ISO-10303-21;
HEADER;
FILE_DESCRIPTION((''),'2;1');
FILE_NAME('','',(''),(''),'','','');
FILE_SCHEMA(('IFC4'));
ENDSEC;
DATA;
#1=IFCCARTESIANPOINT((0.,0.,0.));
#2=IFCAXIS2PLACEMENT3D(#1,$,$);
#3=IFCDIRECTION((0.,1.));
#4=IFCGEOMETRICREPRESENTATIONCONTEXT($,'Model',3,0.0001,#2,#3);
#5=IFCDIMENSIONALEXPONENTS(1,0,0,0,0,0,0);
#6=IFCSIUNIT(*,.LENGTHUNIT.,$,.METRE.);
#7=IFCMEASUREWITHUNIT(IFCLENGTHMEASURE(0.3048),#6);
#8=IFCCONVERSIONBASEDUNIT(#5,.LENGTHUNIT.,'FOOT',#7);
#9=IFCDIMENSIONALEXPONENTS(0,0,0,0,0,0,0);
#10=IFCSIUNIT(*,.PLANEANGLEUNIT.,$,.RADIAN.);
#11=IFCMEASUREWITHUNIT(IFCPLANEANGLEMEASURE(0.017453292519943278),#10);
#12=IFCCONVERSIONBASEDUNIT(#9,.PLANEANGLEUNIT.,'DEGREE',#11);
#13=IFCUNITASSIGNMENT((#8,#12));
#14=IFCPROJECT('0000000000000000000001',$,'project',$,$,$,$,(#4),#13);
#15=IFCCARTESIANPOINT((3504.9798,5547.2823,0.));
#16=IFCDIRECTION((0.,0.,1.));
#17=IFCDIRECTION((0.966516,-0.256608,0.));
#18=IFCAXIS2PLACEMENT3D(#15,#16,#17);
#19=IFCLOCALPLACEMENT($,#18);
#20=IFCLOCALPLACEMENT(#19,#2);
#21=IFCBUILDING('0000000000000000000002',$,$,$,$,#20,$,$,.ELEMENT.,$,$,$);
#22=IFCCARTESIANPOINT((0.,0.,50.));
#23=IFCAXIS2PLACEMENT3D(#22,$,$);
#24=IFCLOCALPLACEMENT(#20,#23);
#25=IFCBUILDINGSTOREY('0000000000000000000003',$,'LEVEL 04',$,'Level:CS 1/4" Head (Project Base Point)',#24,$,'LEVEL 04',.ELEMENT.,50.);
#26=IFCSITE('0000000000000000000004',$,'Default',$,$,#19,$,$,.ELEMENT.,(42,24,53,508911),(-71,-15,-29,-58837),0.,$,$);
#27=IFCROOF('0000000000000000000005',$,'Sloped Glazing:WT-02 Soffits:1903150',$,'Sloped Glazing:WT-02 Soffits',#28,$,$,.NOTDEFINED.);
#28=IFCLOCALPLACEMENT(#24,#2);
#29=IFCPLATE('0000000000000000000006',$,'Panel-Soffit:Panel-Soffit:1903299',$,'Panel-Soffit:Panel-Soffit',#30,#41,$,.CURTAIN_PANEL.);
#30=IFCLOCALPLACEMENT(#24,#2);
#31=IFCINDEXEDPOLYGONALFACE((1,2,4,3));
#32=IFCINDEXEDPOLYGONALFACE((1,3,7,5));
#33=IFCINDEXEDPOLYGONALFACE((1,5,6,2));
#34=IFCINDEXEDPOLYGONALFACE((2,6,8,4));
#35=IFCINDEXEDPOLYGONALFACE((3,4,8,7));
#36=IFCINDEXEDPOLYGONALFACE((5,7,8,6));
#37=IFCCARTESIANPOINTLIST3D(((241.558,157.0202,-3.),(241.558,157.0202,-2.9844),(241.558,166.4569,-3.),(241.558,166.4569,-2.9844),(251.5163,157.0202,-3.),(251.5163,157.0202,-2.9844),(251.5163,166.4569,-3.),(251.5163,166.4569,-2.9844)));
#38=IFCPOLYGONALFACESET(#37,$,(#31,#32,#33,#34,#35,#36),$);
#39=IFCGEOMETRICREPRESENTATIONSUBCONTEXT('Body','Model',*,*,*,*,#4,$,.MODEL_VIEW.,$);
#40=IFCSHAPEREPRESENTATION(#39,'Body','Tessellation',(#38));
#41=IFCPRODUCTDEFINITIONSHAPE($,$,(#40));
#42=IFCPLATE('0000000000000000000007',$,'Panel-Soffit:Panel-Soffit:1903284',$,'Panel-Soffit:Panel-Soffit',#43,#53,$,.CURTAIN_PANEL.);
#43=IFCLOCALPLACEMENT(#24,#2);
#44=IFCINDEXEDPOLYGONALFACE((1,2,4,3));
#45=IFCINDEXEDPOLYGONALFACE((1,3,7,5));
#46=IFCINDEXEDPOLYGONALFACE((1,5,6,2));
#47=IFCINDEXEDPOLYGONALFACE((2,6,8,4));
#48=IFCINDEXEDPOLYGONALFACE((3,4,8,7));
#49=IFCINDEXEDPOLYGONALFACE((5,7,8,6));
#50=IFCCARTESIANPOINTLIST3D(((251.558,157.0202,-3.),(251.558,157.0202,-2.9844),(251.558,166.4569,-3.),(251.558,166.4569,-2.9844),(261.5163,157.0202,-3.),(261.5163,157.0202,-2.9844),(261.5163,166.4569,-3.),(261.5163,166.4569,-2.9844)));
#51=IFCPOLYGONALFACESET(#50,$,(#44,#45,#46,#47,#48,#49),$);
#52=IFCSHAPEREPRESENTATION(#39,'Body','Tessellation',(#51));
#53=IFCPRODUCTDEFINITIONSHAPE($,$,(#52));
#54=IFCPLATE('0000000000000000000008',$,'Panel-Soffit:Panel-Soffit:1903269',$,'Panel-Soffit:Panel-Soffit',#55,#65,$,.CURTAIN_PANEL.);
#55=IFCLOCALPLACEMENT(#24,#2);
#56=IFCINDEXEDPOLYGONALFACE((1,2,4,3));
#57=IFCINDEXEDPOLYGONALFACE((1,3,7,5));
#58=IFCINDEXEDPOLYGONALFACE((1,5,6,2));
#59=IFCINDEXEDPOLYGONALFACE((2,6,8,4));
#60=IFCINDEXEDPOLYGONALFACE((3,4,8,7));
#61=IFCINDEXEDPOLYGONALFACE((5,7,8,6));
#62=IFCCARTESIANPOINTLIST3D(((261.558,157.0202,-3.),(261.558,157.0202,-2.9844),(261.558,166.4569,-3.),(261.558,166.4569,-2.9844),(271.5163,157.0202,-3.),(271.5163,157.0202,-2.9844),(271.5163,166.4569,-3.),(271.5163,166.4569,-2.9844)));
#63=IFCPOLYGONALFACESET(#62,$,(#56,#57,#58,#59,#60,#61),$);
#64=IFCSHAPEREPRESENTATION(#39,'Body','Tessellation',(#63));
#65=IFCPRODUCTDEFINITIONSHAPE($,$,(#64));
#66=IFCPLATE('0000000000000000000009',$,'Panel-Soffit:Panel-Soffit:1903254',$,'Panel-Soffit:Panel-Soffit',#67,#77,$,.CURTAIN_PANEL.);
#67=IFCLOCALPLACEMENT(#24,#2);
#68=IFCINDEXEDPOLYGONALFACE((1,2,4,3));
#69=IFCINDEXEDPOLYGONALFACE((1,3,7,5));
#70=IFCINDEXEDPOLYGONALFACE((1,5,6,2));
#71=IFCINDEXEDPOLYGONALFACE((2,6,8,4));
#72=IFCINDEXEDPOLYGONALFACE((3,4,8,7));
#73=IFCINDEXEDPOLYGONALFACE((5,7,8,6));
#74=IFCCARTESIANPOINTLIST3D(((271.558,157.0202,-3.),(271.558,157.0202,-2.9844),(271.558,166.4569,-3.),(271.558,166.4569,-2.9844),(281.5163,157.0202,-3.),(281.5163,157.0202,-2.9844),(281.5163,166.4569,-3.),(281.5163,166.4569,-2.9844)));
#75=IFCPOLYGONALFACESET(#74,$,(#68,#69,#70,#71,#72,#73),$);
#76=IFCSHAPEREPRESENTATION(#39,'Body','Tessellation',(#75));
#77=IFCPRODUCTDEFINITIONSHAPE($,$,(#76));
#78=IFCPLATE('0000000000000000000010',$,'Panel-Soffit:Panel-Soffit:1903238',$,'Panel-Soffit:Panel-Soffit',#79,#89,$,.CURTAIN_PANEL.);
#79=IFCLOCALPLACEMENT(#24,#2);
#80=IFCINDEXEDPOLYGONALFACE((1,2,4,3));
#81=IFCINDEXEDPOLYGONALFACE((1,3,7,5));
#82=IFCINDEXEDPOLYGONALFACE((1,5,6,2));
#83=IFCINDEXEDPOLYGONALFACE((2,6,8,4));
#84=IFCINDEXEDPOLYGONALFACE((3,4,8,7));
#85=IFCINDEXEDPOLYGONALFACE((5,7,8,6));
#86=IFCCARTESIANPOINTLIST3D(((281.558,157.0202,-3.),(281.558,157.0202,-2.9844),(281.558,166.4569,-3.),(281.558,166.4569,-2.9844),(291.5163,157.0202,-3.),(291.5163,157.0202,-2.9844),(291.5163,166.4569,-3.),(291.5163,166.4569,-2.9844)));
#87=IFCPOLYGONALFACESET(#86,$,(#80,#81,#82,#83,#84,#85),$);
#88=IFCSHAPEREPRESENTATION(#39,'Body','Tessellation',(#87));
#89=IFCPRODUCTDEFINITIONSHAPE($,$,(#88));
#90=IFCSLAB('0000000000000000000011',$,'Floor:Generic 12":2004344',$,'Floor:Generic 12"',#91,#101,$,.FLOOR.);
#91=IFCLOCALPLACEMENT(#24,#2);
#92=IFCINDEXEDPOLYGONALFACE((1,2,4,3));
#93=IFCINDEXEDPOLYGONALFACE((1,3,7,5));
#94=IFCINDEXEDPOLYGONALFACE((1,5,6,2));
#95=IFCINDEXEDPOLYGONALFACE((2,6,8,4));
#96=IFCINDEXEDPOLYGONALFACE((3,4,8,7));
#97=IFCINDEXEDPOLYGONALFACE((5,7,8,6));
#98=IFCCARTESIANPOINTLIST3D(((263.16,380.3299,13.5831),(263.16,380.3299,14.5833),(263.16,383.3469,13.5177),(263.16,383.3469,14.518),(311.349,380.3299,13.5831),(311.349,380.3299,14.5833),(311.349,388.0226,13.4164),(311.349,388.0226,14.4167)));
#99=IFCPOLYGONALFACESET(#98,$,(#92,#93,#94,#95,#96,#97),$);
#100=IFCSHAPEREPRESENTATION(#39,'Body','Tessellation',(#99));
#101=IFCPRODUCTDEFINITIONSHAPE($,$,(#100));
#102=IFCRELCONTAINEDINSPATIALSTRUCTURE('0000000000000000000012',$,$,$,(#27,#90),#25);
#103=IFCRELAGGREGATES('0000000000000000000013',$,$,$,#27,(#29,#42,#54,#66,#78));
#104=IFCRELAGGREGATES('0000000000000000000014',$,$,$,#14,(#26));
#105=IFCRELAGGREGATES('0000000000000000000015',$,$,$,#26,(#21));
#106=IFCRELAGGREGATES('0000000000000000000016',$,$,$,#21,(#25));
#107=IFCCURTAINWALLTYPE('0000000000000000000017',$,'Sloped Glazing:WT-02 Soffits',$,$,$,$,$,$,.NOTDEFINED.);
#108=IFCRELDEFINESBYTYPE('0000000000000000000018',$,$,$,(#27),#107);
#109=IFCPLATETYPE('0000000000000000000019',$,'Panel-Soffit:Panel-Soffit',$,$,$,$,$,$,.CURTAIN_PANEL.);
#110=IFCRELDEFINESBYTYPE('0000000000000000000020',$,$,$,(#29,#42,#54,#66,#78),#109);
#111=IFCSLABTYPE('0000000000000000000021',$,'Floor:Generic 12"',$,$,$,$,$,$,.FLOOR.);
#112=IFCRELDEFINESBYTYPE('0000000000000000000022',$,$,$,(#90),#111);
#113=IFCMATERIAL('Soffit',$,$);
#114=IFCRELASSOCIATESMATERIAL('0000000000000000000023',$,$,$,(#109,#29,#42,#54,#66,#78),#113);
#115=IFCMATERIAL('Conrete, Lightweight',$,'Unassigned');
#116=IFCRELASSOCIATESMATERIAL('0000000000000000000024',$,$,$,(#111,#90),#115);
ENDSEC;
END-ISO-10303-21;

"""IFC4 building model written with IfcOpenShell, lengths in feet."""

from ifc_helpers import new_model, entity, si_unit, converted_unit, direction, frame, origin, place, context, subcontext, project, spatial, polyline, indexed_curve, outline, extrude, source, transform, mapped, material, type_object, type_shapes, element, aggregate, save


model = new_model("IFC4")

# Units and contexts
model_context = context("Model", 3, precision=0.0001, world=origin(), true_north=direction((0.0, 1.0)))
body_context = subcontext(model_context, "Body", "Model", "MODEL_VIEW")
ifc_project = project(units=[converted_unit("LENGTHUNIT", "FOOT", entity("IfcLengthMeasure", 0.3048), si_unit("LENGTHUNIT", "METRE"), dimensions=[1, 0, 0, 0, 0, 0, 0]), converted_unit("PLANEANGLEUNIT", "DEGREE", entity("IfcPlaneAngleMeasure", 0.017453292519943278), si_unit("PLANEANGLEUNIT", "RADIAN"), dimensions=[0, 0, 0, 0, 0, 0, 0])], contexts=[model_context])

# Site, building, storey
site_placement = place(None, frame((3504.9798, 5547.2823, 0.0), z_axis=(0.0, 0.0, 1.0), x_axis=(0.966516, -0.256608, 0.0)))
site = spatial("IfcSite", under=ifc_project, at=site_placement, Name="Default", CompositionType="ELEMENT", RefLatitude=(42, 24, 53, 508911), RefLongitude=(-71, -15, -29, -58837), RefElevation=0.0)
building_placement = place(site_placement, origin())
building = spatial("IfcBuilding", under=site, at=building_placement, CompositionType="ELEMENT")
storey_placement = place(building_placement, frame((0.0, 0.0, 50.0)))
storey = spatial("IfcBuildingStorey", under=building, at=storey_placement, Name="LEVEL 04", ObjectType="Level:CS 1/4\" Head (Project Base Point)", LongName="LEVEL 04", CompositionType="ELEMENT", Elevation=50.0)

# Roof, plates
curtain_wall_type_1 = type_object("IfcCurtainWallType", Name="Sloped Glazing:WT-02 Soffits", PredefinedType="NOTDEFINED")
roof_placement = place(storey_placement, frame((0.0, 0.0, -50.0)))
roof = element("IfcRoof", 1, at=roof_placement, inside=storey, type_object=curtain_wall_type_1, Name="Sloped Glazing:WT-02 Soffits:1903150", ObjectType="Sloped Glazing:WT-02 Soffits", PredefinedType="NOTDEFINED")
ifc_material_1 = material(Name="Soffit")
plate_type_1 = type_object("IfcPlateType", Name="Panel-Soffit:Panel-Soffit", PredefinedType="CURTAIN_PANEL", material=ifc_material_1)
shared_shape_1 = source(origin(), body_context, "Body", "SweptSolid", [
    extrude(outline(indexed_curve([(-0.0078, -4.9792), (0.0078, -4.9792), (0.0078, 4.9792), (-0.0078, 4.9792), (-0.0078, -4.9792)], self_intersect=False)), frame((0.0, -0.0078, 0.0208), z_axis=(0.0, 0.0, 1.0), x_axis=(0.0, -1.0, 0.0)), (0.0, 0.0, 1.0), 9.4367),
])
type_shapes(plate_type_1, [shared_shape_1])
plate_1_placement = place(roof_placement, frame((246.5372, 156.9993, 47.0), z_axis=(0.0, 1.0, 0.0), x_axis=(1.0, 0.0, 0.0)))
plate_1 = element("IfcPlate", 2, at=plate_1_placement, type_object=plate_type_1, material=ifc_material_1, Name="Panel-Soffit:Panel-Soffit:1903299", ObjectType="Panel-Soffit:Panel-Soffit", PredefinedType="CURTAIN_PANEL", context=body_context, shape_type="MappedRepresentation", body=[
    mapped(shared_shape_1, transform((0.0, 0.0, 0.0), scale=1.0)),
])
plate_2_placement = place(roof_placement, frame((256.5372, 156.9993, 47.0), z_axis=(0.0, 1.0, 0.0), x_axis=(1.0, 0.0, 0.0)))
plate_2 = element("IfcPlate", 3, at=plate_2_placement, type_object=plate_type_1, material=ifc_material_1, Name="Panel-Soffit:Panel-Soffit:1903284", ObjectType="Panel-Soffit:Panel-Soffit", PredefinedType="CURTAIN_PANEL", context=body_context, shape_type="MappedRepresentation", body=[
    mapped(shared_shape_1, transform((0.0, 0.0, 0.0), scale=1.0)),
])
plate_3_placement = place(roof_placement, frame((266.5372, 156.9993, 47.0), z_axis=(0.0, 1.0, 0.0), x_axis=(1.0, 0.0, 0.0)))
plate_3 = element("IfcPlate", 4, at=plate_3_placement, type_object=plate_type_1, material=ifc_material_1, Name="Panel-Soffit:Panel-Soffit:1903269", ObjectType="Panel-Soffit:Panel-Soffit", PredefinedType="CURTAIN_PANEL", context=body_context, shape_type="MappedRepresentation", body=[
    mapped(shared_shape_1, transform((0.0, 0.0, 0.0), scale=1.0)),
])
plate_4_placement = place(roof_placement, frame((276.5372, 156.9993, 47.0), z_axis=(0.0, 1.0, 0.0), x_axis=(1.0, 0.0, 0.0)))
plate_4 = element("IfcPlate", 5, at=plate_4_placement, type_object=plate_type_1, material=ifc_material_1, Name="Panel-Soffit:Panel-Soffit:1903254", ObjectType="Panel-Soffit:Panel-Soffit", PredefinedType="CURTAIN_PANEL", context=body_context, shape_type="MappedRepresentation", body=[
    mapped(shared_shape_1, transform((0.0, 0.0, 0.0), scale=1.0)),
])
plate_5_placement = place(roof_placement, frame((286.5372, 156.9993, 47.0), z_axis=(0.0, 1.0, 0.0), x_axis=(1.0, 0.0, 0.0)))
plate_5 = element("IfcPlate", 6, at=plate_5_placement, type_object=plate_type_1, material=ifc_material_1, Name="Panel-Soffit:Panel-Soffit:1903238", ObjectType="Panel-Soffit:Panel-Soffit", PredefinedType="CURTAIN_PANEL", context=body_context, shape_type="MappedRepresentation", body=[
    mapped(shared_shape_1, transform((0.0, 0.0, 0.0), scale=1.0)),
])
aggregate(roof, [plate_1, plate_2, plate_3, plate_4, plate_5])

# Slab
ifc_material_2 = material(Name="Conrete, Lightweight", Category="Unassigned")
slab_type = type_object("IfcSlabType", Name="Floor:Generic 12\"", PredefinedType="FLOOR", material=ifc_material_2)
slab_1_placement = place(storey_placement, frame((263.16, 380.3299, 13.4164)))
element("IfcSlab", 7, at=slab_1_placement, inside=storey, type_object=slab_type, material=ifc_material_2, Name="Floor:Generic 12\":2004344", ObjectType="Floor:Generic 12\"", PredefinedType="FLOOR", context=body_context, shape_type="SweptSolid", body=[
    extrude(outline(polyline([(24.0945, 7.6945), (-24.0945, 3.0177), (-24.0945, 0.0), (24.0945, 0.0), (24.0945, 7.6945)])), frame((24.0945, 0.0, 1.1669), z_axis=(0.0, 0.021661, 0.999765), x_axis=(1.0, 0.0, 0.0)), (0.0, 0.021661, -0.999765), 1.0002),
])

save(model, "model.ifc")
